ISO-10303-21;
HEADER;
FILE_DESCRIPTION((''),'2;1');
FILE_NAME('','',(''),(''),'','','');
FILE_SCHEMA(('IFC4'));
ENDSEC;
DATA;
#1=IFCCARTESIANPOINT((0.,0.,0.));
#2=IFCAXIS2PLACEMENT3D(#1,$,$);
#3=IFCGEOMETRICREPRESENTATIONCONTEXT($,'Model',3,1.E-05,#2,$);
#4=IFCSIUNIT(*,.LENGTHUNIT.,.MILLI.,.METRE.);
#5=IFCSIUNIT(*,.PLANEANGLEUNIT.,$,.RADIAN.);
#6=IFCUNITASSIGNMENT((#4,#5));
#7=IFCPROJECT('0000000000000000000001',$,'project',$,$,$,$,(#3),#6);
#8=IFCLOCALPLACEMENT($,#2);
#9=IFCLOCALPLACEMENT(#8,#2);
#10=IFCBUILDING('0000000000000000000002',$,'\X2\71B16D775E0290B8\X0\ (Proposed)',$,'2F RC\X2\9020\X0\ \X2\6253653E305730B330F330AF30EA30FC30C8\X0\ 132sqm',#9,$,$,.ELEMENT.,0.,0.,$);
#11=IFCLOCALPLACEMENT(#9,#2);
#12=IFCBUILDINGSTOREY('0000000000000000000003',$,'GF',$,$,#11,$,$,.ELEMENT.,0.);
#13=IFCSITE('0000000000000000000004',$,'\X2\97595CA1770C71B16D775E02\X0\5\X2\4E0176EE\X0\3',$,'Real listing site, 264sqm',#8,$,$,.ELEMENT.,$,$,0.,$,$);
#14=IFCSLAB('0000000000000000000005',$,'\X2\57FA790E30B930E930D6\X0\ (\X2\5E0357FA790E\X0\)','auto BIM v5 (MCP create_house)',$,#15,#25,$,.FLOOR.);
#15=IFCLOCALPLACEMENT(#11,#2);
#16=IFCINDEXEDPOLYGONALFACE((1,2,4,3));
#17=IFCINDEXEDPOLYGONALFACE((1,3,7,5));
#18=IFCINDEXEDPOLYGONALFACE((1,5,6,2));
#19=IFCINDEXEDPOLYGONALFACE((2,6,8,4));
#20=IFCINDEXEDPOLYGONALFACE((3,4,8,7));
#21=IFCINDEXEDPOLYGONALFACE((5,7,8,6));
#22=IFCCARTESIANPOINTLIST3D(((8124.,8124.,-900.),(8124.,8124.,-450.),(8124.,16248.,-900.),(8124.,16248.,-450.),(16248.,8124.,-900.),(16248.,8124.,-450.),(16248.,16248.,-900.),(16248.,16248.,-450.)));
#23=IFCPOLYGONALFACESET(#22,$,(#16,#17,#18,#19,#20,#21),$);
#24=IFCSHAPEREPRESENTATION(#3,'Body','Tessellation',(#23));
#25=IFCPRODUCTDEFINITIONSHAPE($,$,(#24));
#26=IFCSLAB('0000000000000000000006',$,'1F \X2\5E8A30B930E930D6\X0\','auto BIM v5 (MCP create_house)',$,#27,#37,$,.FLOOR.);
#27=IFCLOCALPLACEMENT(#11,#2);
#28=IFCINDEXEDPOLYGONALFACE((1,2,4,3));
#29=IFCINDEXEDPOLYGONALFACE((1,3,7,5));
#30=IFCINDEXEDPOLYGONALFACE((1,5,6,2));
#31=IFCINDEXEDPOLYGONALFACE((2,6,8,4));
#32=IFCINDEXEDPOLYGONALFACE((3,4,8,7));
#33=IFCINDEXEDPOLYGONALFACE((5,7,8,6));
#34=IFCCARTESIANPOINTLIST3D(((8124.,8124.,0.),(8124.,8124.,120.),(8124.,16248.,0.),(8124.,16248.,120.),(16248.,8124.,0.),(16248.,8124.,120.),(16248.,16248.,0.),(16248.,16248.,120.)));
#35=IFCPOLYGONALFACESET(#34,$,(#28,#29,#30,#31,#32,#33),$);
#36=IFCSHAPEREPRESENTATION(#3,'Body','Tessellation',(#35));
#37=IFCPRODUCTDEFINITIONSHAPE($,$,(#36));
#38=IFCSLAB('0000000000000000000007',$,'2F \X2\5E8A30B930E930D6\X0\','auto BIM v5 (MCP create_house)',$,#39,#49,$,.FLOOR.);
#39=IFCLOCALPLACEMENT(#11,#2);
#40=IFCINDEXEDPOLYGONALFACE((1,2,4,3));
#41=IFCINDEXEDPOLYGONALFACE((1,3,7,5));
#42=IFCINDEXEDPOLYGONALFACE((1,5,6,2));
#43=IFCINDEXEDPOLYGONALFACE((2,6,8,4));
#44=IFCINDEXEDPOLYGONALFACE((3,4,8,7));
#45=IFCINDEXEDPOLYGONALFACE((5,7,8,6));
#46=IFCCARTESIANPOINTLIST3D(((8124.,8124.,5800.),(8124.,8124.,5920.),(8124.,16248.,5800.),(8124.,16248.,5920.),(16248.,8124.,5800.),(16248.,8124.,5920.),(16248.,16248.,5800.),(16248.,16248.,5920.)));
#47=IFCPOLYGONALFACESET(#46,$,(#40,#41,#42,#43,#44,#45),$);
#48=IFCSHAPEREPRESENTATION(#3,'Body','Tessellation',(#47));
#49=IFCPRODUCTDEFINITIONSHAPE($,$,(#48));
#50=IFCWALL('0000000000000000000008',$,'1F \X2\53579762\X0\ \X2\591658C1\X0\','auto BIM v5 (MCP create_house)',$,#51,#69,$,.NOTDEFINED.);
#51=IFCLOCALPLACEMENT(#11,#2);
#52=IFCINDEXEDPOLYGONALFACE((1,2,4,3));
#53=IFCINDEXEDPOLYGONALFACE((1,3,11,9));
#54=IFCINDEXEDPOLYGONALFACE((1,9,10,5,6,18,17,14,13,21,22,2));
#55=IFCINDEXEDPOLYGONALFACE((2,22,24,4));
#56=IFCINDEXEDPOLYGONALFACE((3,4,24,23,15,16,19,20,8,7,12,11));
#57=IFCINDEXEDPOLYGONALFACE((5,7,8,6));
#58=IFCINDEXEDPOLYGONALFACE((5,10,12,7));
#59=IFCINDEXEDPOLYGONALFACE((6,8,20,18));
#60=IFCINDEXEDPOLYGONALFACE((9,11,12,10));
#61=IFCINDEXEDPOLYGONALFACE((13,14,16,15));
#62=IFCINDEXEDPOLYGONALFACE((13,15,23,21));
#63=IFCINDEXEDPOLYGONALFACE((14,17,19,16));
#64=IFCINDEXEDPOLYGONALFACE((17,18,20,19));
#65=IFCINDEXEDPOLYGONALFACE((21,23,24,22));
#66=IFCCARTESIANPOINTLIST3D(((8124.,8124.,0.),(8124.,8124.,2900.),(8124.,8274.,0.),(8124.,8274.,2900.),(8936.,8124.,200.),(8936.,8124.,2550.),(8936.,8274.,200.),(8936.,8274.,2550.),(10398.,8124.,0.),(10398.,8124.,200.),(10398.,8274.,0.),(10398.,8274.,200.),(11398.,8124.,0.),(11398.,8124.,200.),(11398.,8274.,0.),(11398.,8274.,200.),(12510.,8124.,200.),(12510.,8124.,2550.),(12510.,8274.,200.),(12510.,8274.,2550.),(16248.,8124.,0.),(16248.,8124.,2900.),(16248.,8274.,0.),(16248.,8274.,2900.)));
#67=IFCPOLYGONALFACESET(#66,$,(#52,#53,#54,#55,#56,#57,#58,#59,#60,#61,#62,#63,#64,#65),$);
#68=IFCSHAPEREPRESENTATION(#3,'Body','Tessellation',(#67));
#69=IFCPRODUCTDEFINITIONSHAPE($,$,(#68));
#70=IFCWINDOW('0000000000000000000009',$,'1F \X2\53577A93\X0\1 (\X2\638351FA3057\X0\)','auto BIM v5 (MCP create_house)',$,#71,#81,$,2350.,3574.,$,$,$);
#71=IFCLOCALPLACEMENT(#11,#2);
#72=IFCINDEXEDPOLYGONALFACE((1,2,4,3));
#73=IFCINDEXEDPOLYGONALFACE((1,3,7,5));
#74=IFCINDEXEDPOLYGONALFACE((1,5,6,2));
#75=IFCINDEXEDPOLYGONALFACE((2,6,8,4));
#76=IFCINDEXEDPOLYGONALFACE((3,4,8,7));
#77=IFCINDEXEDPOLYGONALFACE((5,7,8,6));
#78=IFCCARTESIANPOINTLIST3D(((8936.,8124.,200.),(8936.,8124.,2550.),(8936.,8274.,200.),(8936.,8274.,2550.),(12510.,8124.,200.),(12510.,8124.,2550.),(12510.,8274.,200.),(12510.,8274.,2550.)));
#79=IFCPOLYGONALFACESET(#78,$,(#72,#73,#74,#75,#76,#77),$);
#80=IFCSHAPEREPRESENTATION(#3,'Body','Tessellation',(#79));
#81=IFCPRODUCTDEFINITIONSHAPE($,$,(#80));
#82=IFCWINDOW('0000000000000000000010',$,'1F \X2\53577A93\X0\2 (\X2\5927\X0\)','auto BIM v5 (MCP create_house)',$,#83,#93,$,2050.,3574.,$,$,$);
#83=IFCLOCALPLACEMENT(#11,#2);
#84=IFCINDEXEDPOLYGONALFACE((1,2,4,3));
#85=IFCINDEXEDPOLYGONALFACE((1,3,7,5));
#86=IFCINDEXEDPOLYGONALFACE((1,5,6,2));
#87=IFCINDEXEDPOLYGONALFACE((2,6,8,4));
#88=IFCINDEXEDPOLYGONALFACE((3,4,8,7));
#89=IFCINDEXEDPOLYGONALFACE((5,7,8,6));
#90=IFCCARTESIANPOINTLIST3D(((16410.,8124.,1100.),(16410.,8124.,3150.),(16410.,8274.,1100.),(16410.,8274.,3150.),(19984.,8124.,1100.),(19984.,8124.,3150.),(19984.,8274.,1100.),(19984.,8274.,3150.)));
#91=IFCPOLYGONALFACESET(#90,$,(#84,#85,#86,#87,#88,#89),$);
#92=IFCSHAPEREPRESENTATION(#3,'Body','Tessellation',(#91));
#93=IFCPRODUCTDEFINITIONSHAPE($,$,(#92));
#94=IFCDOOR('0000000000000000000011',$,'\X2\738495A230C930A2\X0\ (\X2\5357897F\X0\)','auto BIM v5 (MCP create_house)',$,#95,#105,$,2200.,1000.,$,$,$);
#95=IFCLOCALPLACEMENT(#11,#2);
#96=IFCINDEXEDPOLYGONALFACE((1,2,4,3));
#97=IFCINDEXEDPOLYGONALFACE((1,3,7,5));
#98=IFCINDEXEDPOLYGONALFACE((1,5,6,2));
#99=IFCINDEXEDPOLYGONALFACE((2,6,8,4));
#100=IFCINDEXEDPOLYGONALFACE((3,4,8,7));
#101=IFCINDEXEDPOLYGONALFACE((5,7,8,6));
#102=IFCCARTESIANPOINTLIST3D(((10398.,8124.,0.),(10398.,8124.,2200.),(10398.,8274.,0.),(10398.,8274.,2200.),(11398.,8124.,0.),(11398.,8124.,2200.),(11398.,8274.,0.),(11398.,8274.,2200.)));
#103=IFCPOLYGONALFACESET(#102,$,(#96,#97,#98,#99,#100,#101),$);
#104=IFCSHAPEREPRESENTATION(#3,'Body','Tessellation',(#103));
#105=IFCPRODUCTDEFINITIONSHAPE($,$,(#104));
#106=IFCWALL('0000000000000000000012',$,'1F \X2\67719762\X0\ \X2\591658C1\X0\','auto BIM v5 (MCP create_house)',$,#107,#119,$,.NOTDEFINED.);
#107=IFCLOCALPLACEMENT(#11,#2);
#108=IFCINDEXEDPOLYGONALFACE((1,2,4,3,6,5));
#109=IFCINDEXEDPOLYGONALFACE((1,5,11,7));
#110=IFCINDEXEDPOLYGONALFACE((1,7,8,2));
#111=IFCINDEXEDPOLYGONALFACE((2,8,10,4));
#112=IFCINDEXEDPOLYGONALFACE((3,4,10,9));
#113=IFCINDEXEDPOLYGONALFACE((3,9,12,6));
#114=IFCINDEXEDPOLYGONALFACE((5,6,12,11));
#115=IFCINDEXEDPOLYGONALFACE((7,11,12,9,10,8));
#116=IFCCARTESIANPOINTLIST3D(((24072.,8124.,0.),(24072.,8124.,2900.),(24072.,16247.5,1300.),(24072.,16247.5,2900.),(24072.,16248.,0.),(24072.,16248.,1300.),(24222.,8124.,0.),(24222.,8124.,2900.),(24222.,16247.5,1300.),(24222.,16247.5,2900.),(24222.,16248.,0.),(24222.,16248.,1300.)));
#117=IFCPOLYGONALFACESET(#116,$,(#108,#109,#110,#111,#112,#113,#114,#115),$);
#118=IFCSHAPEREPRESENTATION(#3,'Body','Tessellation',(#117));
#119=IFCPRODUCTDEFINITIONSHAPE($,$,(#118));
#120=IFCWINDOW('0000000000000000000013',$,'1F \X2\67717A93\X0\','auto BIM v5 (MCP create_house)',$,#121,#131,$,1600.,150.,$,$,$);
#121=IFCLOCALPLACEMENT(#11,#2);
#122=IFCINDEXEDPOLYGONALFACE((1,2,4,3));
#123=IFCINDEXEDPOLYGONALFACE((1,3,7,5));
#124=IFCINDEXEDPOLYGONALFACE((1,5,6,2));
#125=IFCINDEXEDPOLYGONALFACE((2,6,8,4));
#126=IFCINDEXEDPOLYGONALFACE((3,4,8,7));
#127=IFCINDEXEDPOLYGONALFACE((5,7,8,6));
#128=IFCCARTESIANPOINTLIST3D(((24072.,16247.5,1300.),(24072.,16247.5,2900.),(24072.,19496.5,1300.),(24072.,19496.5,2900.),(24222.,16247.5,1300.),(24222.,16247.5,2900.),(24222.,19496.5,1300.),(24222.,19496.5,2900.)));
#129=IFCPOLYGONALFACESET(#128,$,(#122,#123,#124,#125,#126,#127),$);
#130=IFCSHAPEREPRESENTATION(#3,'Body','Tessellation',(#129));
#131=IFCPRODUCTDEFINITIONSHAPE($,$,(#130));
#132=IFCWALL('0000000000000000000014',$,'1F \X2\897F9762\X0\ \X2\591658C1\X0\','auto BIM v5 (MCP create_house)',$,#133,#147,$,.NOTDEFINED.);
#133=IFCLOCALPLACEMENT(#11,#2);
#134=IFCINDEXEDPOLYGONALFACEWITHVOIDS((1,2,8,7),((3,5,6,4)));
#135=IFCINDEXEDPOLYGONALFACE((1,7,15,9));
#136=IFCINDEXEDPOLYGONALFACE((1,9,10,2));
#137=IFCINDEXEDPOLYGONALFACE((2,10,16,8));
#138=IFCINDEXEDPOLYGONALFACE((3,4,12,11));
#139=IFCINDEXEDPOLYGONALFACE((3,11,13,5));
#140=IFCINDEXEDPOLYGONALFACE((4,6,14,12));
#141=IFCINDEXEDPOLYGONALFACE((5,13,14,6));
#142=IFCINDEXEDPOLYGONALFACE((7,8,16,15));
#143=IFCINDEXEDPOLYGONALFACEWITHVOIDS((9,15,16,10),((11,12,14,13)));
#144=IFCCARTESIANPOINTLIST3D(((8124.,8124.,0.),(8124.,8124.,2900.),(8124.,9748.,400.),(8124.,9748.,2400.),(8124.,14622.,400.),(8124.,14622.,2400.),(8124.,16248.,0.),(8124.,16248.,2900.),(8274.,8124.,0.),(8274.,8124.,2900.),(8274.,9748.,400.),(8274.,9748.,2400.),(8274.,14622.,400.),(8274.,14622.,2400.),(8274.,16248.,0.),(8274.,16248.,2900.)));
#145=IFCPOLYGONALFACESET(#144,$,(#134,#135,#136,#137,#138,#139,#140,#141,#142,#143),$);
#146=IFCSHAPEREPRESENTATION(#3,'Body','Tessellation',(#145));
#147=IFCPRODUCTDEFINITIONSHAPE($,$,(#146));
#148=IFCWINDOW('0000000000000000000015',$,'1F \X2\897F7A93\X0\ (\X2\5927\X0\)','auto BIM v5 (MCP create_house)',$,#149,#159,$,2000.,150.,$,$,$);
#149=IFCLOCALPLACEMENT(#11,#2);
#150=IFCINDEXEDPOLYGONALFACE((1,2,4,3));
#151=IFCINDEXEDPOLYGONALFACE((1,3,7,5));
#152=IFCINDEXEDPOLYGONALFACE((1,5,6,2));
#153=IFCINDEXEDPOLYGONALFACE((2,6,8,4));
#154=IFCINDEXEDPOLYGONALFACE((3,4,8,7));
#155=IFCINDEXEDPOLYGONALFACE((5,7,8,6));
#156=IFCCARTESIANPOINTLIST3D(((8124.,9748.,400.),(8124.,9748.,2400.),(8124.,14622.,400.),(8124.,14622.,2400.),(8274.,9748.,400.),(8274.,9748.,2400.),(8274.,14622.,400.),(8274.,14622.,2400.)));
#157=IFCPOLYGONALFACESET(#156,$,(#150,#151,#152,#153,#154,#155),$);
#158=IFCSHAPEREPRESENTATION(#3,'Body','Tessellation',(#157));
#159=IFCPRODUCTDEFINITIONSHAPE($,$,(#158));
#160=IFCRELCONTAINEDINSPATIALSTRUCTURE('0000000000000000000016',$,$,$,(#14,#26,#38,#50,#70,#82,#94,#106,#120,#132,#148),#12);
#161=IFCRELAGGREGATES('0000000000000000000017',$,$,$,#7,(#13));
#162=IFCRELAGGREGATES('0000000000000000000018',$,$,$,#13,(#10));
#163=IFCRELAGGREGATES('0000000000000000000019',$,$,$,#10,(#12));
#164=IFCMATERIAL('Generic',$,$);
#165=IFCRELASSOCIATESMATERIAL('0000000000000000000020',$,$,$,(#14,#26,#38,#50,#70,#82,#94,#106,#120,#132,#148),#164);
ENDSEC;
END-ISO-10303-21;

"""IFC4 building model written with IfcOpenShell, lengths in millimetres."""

from ifc_helpers import new_model, si_unit, frame, frame_2d, origin, place, context, project, spatial, rectangle, extrude, material, element, fill, save


model = new_model("IFC4")

# Units and contexts
model_context = context("Model", 3, precision=1e-05, world=origin())
ifc_project = project(units=[si_unit("LENGTHUNIT", "METRE", prefix="MILLI"), si_unit("PLANEANGLEUNIT", "RADIAN")], contexts=[model_context])

# Site, building, storey
site_placement = place(None, origin())
site = spatial("IfcSite", under=ifc_project, at=site_placement, Name="静岡県熱海市5丁目3", ObjectType="Real listing site, 264sqm", CompositionType="ELEMENT", RefElevation=0.0)
building_placement = place(site_placement, origin())
building = spatial("IfcBuilding", under=site, at=building_placement, Name="熱海市邸 (Proposed)", ObjectType="2F RC造 打放しコンクリート 132sqm", CompositionType="ELEMENT", ElevationOfRefHeight=0.0, ElevationOfTerrain=0.0)
storey_placement = place(building_placement, origin())
storey = spatial("IfcBuildingStorey", under=building, at=storey_placement, Name="GF", CompositionType="ELEMENT", Elevation=0.0)

# Slabs
ifc_material = material(Name="Generic")
slab_1_placement = place(storey_placement, frame((4062.0, 4062.0, -450.0)))
element("IfcSlab", 1, at=slab_1_placement, inside=storey, material=ifc_material, Name="基礎スラブ (布基礎)", Description="auto BIM v5 (MCP create_house)", PredefinedType="FLOOR", context=model_context, shape_type="SweptSolid", body=[
    extrude(rectangle(XDim=8124.0, YDim=8124.0, at=frame_2d((4062.0, 4062.0))), frame((4062.0, 4062.0, -450.0)), (0.0, 0.0, 1.0), 450.0),
])
slab_2_placement = place(storey_placement, frame((4062.0, 4062.0, 0.0)))
element("IfcSlab", 2, at=slab_2_placement, inside=storey, material=ifc_material, Name="1F 床スラブ", Description="auto BIM v5 (MCP create_house)", PredefinedType="FLOOR", context=model_context, shape_type="SweptSolid", body=[
    extrude(rectangle(XDim=8124.0, YDim=8124.0, at=frame_2d((4062.0, 4062.0))), frame((4062.0, 4062.0, 0.0)), (0.0, 0.0, 1.0), 120.0),
])
slab_3_placement = place(storey_placement, frame((4062.0, 4062.0, 2900.0)))
element("IfcSlab", 3, at=slab_3_placement, inside=storey, material=ifc_material, Name="2F 床スラブ", Description="auto BIM v5 (MCP create_house)", PredefinedType="FLOOR", context=model_context, shape_type="SweptSolid", body=[
    extrude(rectangle(XDim=8124.0, YDim=8124.0, at=frame_2d((4062.0, 4062.0))), frame((4062.0, 4062.0, 2900.0)), (0.0, 0.0, 1.0), 120.0),
])

# Wall, openings, windows, door
wall_1_placement = place(storey_placement, frame((4062.0, 4062.0, 0.0)))
wall_1 = element("IfcWall", 4, at=wall_1_placement, inside=storey, material=ifc_material, Name="1F 南面 外壁", Description="auto BIM v5 (MCP create_house)", PredefinedType="NOTDEFINED", context=model_context, shape_type="SweptSolid", body=[
    extrude(rectangle(XDim=8124.0, YDim=150.0, at=frame_2d((4062.0, 75.0))), frame((4062.0, 4062.0, 0.0)), (0.0, 0.0, 1.0), 2900.0),
])
opening_1_placement = place(storey_placement, frame((4468.0, 4062.0, 100.0)))
opening_1 = element("IfcOpeningElement", 5, at=opening_1_placement, cuts=wall_1, PredefinedType="NOTDEFINED", context=model_context, shape_type="SweptSolid", body=[
    extrude(rectangle(XDim=3574.0, YDim=150.0, at=frame_2d((1787.0, 75.0))), frame((4468.0, 4062.0, 100.0)), (0.0, 0.0, 1.0), 2350.0),
])
opening_2_placement = place(storey_placement, frame((8205.0, 4062.0, 550.0)))
opening_2 = element("IfcOpeningElement", 6, at=opening_2_placement, cuts=wall_1, PredefinedType="NOTDEFINED", context=model_context, shape_type="SweptSolid", body=[
    extrude(rectangle(XDim=3574.0, YDim=150.0, at=frame_2d((1787.0, 75.0))), frame((8205.0, 4062.0, 550.0)), (0.0, 0.0, 1.0), 2050.0),
])
opening_3_placement = place(storey_placement, frame((5199.0, 4062.0, 0.0)))
opening_3 = element("IfcOpeningElement", 7, at=opening_3_placement, cuts=wall_1, PredefinedType="NOTDEFINED", context=model_context, shape_type="SweptSolid", body=[
    extrude(rectangle(XDim=1000.0, YDim=150.0, at=frame_2d((500.0, 75.0))), frame((5199.0, 4062.0, 0.0)), (0.0, 0.0, 1.0), 2200.0),
])
window_1_placement = place(storey_placement, frame((4468.0, 4062.0, 100.0)))
window_1 = element("IfcWindow", 8, at=window_1_placement, inside=storey, material=ifc_material, Name="1F 南窓1 (掃出し)", Description="auto BIM v5 (MCP create_house)", OverallHeight=2350.0, OverallWidth=3574.0, context=model_context, shape_type="SweptSolid", body=[
    extrude(rectangle(XDim=3574.0, YDim=150.0, at=frame_2d((1787.0, 75.0))), frame((4468.0, 4062.0, 100.0)), (0.0, 0.0, 1.0), 2350.0),
])
fill(opening_1, window_1)
window_2_placement = place(storey_placement, frame((8205.0, 4062.0, 550.0)))
window_2 = element("IfcWindow", 9, at=window_2_placement, inside=storey, material=ifc_material, Name="1F 南窓2 (大)", Description="auto BIM v5 (MCP create_house)", OverallHeight=2050.0, OverallWidth=3574.0, context=model_context, shape_type="SweptSolid", body=[
    extrude(rectangle(XDim=3574.0, YDim=150.0, at=frame_2d((1787.0, 75.0))), frame((8205.0, 4062.0, 550.0)), (0.0, 0.0, 1.0), 2050.0),
])
fill(opening_2, window_2)
door_placement = place(storey_placement, frame((5199.0, 4062.0, 0.0)))
door = element("IfcDoor", 10, at=door_placement, inside=storey, material=ifc_material, Name="玄関ドア (南西)", Description="auto BIM v5 (MCP create_house)", OverallHeight=2200.0, OverallWidth=1000.0, context=model_context, shape_type="SweptSolid", body=[
    extrude(rectangle(XDim=1000.0, YDim=150.0, at=frame_2d((500.0, 75.0))), frame((5199.0, 4062.0, 0.0)), (0.0, 0.0, 1.0), 2200.0),
])
fill(opening_3, door)

# Walls, openings, windows
wall_2_placement = place(storey_placement, frame((12036.0, 4062.0, 0.0)))
wall_2 = element("IfcWall", 11, at=wall_2_placement, inside=storey, material=ifc_material, Name="1F 東面 外壁", Description="auto BIM v5 (MCP create_house)", PredefinedType="NOTDEFINED", context=model_context, shape_type="SweptSolid", body=[
    extrude(rectangle(XDim=150.0, YDim=8124.0, at=frame_2d((75.0, 4062.0))), frame((12036.0, 4062.0, 0.0)), (0.0, 0.0, 1.0), 2900.0),
])
opening_4_placement = place(storey_placement, frame((12036.0, 8124.0, 650.0)))
opening_4 = element("IfcOpeningElement", 12, at=opening_4_placement, cuts=wall_2, PredefinedType="NOTDEFINED", context=model_context, shape_type="SweptSolid", body=[
    extrude(rectangle(XDim=150.0, YDim=3249.0, at=frame_2d((75.0, 1624.0))), frame((12036.0, 8124.0, 650.0)), (0.0, 0.0, 1.0), 1600.0),
])
window_3_placement = place(storey_placement, frame((12036.0, 8124.0, 650.0)))
window_3 = element("IfcWindow", 13, at=window_3_placement, inside=storey, material=ifc_material, Name="1F 東窓", Description="auto BIM v5 (MCP create_house)", OverallHeight=1600.0, OverallWidth=150.0, context=model_context, shape_type="SweptSolid", body=[
    extrude(rectangle(XDim=150.0, YDim=3249.0, at=frame_2d((75.0, 1624.0))), frame((12036.0, 8124.0, 650.0)), (0.0, 0.0, 1.0), 1600.0),
])
fill(opening_4, window_3)
wall_3_placement = place(storey_placement, frame((4062.0, 4062.0, 0.0)))
wall_3 = element("IfcWall", 14, at=wall_3_placement, inside=storey, material=ifc_material, Name="1F 西面 外壁", Description="auto BIM v5 (MCP create_house)", PredefinedType="NOTDEFINED", context=model_context, shape_type="SweptSolid", body=[
    extrude(rectangle(XDim=150.0, YDim=8124.0, at=frame_2d((75.0, 4062.0))), frame((4062.0, 4062.0, 0.0)), (0.0, 0.0, 1.0), 2900.0),
])
opening_5_placement = place(storey_placement, frame((4062.0, 4874.0, 200.0)))
opening_5 = element("IfcOpeningElement", 15, at=opening_5_placement, cuts=wall_3, PredefinedType="NOTDEFINED", context=model_context, shape_type="SweptSolid", body=[
    extrude(rectangle(XDim=150.0, YDim=4874.0, at=frame_2d((75.0, 2437.0))), frame((4062.0, 4874.0, 200.0)), (0.0, 0.0, 1.0), 2000.0),
])
window_4_placement = place(storey_placement, frame((4062.0, 4874.0, 200.0)))
window_4 = element("IfcWindow", 16, at=window_4_placement, inside=storey, material=ifc_material, Name="1F 西窓 (大)", Description="auto BIM v5 (MCP create_house)", OverallHeight=2000.0, OverallWidth=150.0, context=model_context, shape_type="SweptSolid", body=[
    extrude(rectangle(XDim=150.0, YDim=4874.0, at=frame_2d((75.0, 2437.0))), frame((4062.0, 4874.0, 200.0)), (0.0, 0.0, 1.0), 2000.0),
])
fill(opening_5, window_4)

save(model, "model.ifc")
